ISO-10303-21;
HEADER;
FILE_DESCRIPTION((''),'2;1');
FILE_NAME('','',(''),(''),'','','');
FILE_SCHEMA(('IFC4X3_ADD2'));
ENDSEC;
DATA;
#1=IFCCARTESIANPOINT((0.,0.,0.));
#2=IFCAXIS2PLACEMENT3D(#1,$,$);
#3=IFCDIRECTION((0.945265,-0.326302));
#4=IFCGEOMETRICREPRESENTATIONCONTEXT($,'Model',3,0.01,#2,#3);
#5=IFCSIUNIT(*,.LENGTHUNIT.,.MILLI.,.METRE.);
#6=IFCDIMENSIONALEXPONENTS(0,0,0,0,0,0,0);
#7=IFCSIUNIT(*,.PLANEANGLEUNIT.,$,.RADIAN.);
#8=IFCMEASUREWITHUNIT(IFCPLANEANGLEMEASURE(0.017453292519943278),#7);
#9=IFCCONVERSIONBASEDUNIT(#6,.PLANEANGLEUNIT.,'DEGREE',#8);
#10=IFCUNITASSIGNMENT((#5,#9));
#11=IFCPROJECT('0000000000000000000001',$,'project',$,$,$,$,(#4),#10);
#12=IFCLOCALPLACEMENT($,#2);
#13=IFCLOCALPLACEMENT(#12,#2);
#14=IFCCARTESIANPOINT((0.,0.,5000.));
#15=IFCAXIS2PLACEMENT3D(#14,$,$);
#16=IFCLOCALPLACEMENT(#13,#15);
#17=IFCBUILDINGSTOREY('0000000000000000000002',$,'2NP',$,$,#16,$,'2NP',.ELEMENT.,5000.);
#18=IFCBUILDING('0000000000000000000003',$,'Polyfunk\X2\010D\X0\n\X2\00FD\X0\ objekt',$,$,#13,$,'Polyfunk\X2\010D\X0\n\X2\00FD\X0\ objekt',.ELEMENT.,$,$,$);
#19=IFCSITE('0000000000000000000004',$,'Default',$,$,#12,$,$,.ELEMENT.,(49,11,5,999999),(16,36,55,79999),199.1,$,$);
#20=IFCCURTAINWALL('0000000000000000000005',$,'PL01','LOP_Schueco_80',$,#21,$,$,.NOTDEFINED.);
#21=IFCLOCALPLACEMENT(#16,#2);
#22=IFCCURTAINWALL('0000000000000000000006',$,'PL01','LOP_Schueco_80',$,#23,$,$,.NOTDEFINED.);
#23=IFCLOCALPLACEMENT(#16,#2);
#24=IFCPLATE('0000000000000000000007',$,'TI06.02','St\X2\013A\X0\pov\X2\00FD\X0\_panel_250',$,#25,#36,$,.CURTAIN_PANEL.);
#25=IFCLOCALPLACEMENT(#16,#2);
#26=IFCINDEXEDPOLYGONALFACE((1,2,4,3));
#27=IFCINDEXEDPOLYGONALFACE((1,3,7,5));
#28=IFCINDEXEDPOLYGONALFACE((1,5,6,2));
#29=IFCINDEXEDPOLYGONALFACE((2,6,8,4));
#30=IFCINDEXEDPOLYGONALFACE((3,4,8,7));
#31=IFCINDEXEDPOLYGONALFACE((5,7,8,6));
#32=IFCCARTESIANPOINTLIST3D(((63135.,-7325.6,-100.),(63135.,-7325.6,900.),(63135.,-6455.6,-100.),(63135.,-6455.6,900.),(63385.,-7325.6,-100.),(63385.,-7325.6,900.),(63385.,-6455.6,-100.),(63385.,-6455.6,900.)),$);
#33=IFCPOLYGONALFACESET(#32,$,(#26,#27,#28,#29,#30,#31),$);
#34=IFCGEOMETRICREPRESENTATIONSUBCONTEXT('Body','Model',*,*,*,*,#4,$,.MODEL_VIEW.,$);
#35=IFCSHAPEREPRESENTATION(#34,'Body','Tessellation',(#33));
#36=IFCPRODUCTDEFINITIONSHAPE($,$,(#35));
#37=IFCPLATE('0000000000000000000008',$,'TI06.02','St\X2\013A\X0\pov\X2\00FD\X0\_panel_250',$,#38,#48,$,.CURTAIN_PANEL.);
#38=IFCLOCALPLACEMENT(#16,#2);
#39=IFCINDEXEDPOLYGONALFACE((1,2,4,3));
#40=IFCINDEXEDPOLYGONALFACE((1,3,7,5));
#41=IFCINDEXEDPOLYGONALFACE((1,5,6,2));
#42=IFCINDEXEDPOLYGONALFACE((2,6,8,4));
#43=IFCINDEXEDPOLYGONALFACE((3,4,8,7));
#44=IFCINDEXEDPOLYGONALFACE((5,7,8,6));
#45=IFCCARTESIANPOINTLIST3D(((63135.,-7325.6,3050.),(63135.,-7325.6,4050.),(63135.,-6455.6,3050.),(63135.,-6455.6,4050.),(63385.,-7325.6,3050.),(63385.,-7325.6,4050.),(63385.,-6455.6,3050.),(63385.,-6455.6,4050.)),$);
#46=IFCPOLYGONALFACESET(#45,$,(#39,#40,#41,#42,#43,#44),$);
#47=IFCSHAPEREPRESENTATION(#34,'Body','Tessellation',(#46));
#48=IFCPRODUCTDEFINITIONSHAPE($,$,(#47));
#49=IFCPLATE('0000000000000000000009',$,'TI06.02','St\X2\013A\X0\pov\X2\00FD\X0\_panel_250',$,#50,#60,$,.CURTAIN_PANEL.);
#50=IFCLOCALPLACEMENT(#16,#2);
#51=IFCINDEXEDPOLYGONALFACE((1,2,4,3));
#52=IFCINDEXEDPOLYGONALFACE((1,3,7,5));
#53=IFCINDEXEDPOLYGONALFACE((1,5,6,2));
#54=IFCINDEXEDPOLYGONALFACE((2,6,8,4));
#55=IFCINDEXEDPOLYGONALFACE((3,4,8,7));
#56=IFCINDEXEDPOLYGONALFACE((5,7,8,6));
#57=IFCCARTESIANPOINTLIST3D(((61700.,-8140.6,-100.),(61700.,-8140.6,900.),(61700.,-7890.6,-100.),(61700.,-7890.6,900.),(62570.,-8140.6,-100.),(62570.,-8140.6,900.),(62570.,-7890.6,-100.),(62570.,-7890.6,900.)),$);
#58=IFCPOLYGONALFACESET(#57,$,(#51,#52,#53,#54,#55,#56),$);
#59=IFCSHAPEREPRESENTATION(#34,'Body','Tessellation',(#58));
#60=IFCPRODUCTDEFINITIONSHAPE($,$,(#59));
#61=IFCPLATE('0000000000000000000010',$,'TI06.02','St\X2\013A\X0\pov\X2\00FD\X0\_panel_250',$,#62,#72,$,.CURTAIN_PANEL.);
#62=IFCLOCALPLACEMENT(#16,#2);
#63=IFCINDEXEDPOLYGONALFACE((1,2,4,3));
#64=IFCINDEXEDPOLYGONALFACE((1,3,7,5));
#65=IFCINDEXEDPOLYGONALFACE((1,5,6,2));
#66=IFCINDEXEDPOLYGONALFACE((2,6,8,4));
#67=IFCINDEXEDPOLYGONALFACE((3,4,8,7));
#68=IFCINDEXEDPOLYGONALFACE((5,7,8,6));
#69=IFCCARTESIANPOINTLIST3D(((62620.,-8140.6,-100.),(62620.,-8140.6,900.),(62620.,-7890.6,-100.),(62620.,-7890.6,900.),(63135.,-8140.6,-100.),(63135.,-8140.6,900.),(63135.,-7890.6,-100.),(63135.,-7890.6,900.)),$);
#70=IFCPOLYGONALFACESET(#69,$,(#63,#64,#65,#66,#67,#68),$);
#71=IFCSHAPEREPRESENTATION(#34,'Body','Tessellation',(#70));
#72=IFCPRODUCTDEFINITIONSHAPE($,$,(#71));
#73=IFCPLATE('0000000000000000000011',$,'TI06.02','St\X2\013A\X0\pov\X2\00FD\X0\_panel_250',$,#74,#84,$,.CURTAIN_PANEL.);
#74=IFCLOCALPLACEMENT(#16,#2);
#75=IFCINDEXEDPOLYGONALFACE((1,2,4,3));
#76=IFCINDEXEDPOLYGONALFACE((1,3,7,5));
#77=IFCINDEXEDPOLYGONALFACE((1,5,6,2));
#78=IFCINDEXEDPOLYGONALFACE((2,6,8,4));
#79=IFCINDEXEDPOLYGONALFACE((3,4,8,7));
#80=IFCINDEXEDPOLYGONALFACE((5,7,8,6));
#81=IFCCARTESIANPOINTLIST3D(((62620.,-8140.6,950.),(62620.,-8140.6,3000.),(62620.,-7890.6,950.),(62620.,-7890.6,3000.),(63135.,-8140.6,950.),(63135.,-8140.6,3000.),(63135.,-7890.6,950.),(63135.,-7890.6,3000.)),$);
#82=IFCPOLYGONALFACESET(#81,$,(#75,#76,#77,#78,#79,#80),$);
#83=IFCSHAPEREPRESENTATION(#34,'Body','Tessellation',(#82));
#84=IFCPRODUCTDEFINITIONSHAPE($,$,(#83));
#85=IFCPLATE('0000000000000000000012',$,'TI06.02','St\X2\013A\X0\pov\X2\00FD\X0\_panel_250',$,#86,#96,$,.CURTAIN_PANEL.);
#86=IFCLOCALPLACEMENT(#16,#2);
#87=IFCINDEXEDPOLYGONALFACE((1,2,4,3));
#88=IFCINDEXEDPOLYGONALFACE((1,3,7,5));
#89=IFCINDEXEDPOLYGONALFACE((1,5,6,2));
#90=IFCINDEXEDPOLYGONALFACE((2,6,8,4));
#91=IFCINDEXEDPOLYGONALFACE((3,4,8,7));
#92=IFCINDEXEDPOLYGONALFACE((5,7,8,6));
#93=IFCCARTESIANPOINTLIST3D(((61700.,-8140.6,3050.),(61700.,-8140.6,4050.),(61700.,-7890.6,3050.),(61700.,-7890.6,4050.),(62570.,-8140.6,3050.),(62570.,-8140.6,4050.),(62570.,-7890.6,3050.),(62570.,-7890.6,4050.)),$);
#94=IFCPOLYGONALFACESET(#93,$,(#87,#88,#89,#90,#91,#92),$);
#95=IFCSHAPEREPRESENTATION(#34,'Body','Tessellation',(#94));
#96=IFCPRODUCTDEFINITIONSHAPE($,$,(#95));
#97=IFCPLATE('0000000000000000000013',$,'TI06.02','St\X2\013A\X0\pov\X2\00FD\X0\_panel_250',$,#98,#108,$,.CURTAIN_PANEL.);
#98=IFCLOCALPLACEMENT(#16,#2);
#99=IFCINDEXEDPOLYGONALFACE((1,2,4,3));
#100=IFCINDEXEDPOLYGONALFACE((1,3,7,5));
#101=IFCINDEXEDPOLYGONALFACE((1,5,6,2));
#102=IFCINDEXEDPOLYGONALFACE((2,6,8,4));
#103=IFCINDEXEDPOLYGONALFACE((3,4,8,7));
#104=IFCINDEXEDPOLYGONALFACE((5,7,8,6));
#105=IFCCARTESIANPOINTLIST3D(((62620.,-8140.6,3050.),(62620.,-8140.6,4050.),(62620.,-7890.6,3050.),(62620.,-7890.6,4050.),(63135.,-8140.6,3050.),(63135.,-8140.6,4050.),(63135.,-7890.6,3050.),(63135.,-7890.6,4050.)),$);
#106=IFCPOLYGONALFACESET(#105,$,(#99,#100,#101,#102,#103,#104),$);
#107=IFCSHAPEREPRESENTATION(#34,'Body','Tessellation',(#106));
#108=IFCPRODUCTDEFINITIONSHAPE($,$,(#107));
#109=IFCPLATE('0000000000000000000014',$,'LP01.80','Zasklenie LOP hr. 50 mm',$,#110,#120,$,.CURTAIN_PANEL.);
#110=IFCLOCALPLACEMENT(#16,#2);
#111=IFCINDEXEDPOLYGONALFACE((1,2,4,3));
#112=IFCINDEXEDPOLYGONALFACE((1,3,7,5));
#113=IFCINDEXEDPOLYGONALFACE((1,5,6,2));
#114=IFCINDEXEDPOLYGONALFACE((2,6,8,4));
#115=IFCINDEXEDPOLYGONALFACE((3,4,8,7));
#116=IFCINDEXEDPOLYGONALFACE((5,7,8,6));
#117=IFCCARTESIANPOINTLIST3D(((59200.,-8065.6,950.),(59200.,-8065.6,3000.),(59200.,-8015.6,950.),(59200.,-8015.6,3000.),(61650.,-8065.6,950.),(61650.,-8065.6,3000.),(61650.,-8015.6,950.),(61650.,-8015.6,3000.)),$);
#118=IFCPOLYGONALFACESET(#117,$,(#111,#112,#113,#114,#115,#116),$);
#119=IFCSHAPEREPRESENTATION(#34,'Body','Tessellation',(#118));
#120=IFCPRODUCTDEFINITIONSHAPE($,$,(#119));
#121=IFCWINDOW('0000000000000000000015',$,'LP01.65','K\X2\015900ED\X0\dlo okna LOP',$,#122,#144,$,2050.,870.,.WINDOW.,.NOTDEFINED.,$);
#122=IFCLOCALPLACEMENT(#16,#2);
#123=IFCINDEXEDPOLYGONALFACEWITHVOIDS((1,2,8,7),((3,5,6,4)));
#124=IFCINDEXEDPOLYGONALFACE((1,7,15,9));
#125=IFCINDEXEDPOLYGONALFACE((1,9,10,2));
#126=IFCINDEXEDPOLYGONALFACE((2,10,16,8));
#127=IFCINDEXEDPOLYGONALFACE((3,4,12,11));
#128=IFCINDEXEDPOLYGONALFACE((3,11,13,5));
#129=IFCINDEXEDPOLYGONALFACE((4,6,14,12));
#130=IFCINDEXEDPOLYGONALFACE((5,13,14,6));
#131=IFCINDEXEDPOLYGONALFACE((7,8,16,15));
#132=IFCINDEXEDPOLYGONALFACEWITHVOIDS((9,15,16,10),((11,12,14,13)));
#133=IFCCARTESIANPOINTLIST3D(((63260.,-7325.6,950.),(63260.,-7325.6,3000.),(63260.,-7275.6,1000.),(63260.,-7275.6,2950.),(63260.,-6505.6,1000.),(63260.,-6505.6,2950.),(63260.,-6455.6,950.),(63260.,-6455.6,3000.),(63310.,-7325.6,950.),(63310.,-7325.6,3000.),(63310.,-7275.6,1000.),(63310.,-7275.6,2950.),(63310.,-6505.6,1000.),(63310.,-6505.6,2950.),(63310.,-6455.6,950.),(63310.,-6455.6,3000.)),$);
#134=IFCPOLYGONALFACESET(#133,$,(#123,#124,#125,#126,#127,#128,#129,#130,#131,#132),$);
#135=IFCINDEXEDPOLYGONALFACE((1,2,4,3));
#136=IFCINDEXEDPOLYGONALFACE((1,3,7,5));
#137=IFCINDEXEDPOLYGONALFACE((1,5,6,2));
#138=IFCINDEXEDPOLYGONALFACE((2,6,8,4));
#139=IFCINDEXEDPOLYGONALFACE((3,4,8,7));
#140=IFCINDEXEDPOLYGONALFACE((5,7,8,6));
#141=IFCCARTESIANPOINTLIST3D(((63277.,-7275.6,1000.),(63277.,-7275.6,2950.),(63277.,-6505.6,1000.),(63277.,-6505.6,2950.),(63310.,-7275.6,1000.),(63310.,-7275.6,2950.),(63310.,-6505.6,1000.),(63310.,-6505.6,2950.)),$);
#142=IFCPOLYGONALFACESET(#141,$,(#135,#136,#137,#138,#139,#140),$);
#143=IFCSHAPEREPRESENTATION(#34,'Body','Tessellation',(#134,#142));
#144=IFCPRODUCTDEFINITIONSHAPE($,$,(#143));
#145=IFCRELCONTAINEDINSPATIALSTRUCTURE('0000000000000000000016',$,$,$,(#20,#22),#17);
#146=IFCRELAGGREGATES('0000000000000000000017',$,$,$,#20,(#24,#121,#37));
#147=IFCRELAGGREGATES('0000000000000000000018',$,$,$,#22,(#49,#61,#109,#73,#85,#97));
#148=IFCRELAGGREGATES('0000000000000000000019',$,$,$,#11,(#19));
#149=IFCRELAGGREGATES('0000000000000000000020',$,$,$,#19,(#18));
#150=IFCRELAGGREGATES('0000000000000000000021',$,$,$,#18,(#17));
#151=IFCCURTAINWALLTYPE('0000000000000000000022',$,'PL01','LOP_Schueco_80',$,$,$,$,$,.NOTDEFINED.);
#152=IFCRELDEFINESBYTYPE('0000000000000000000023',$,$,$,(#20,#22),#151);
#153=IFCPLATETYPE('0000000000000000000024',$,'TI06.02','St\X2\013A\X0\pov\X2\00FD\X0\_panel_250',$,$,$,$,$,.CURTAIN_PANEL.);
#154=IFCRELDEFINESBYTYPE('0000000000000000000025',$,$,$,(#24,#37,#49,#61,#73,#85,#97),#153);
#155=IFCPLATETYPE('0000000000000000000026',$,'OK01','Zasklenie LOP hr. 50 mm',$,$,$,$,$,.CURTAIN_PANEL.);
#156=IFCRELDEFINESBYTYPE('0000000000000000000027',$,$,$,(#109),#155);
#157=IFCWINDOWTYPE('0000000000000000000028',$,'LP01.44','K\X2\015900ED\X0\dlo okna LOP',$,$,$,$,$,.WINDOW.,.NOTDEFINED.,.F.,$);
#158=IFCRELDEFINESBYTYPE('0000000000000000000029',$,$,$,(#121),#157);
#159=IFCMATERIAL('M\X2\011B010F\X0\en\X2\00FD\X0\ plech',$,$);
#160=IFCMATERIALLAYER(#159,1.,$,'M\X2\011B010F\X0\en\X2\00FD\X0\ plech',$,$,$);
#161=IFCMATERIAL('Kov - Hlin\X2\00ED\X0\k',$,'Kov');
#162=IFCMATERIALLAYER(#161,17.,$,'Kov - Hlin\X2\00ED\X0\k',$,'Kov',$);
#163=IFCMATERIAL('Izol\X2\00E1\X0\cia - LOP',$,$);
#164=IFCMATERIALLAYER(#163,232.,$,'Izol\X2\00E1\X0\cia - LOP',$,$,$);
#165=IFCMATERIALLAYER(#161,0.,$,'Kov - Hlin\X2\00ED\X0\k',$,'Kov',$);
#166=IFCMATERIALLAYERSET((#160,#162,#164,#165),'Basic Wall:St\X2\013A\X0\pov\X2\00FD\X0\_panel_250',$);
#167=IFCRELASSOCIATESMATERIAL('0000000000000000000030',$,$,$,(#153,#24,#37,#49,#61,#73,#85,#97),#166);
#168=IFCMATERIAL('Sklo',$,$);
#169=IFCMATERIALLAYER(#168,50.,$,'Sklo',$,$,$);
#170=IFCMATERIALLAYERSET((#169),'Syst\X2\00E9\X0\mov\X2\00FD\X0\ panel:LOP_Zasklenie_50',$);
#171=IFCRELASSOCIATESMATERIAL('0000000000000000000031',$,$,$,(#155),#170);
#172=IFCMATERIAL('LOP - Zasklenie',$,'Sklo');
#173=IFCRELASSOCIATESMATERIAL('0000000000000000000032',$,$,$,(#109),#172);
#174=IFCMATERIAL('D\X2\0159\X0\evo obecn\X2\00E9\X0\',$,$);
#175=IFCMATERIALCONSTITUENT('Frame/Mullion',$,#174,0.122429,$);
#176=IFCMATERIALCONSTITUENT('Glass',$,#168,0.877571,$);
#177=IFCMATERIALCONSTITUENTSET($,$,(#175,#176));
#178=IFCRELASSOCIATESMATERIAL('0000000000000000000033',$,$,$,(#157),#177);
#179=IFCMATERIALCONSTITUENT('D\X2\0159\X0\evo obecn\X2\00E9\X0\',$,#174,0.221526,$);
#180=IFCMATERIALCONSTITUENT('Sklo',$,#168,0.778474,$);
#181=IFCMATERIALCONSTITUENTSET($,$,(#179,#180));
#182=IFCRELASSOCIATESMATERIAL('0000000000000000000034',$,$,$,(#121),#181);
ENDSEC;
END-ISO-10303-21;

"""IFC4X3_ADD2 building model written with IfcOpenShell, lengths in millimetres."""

from ifc_helpers import new_model, entity, si_unit, converted_unit, direction, frame, frame_2d, origin, origin_2d_with_axis, place, context, subcontext, project, spatial, polyline, rectangle, outline, extrude, source, transform, mapped, material, layer, layer_set, layer_usage, constituent, constituent_set, type_object, type_shapes, element, aggregate, save


model = new_model("IFC4X3_ADD2")

# Units and contexts
model_context = context("Model", 3, precision=0.01, world=origin(), true_north=direction((0.945265, -0.326302)))
body_context = subcontext(model_context, "Body", "Model", "MODEL_VIEW")
ifc_project = project(units=[si_unit("LENGTHUNIT", "METRE", prefix="MILLI"), converted_unit("PLANEANGLEUNIT", "DEGREE", entity("IfcPlaneAngleMeasure", 0.017453292519943278), si_unit("PLANEANGLEUNIT", "RADIAN"), dimensions=[0, 0, 0, 0, 0, 0, 0])], contexts=[model_context])

# Site, building, storey
site_placement = place(None, origin())
site = spatial("IfcSite", under=ifc_project, at=site_placement, Name="Default", CompositionType="ELEMENT", RefLatitude=(49, 11, 5, 999999), RefLongitude=(16, 36, 55, 79999), RefElevation=199.1)
building_placement = place(site_placement, origin())
building = spatial("IfcBuilding", under=site, at=building_placement, Name="Polyfunkčný objekt", LongName="Polyfunkčný objekt", CompositionType="ELEMENT")
storey_placement = place(building_placement, frame((0.0, 0.0, 5000.0)))
storey = spatial("IfcBuildingStorey", under=building, at=storey_placement, Name="2NP", LongName="2NP", CompositionType="ELEMENT", Elevation=5000.0)

# Curtain walls
curtain_wall_type = type_object("IfcCurtainWallType", Name="PL01", Description="LOP_Schueco_80", PredefinedType="NOTDEFINED")
curtain_wall_1_placement = place(storey_placement, frame((0.0, 0.0, -5000.0)))
curtain_wall_1 = element("IfcCurtainWall", 1, at=curtain_wall_1_placement, inside=storey, type_object=curtain_wall_type, Name="PL01", Description="LOP_Schueco_80", PredefinedType="NOTDEFINED")
curtain_wall_2_placement = place(storey_placement, frame((0.0, 0.0, -5000.0)))
curtain_wall_2 = element("IfcCurtainWall", 2, at=curtain_wall_2_placement, inside=storey, type_object=curtain_wall_type, Name="PL01", Description="LOP_Schueco_80", PredefinedType="NOTDEFINED")

# Plates
ifc_material_1 = material(Name="Měďený plech")
ifc_layer_1 = layer(ifc_material_1, 1.0, Name="Měďený plech")
ifc_material_2 = material(Name="Kov - Hliník", Category="Kov")
ifc_layer_2 = layer(ifc_material_2, 17.0, Name="Kov - Hliník", Category="Kov")
ifc_material_3 = material(Name="Izolácia - LOP")
ifc_layer_3 = layer(ifc_material_3, 232.0, Name="Izolácia - LOP")
ifc_layer_4 = layer(ifc_material_2, 0.0, Name="Kov - Hliník", Category="Kov")
ifc_layer_set_1 = layer_set([ifc_layer_1, ifc_layer_2, ifc_layer_3, ifc_layer_4], Name="Basic Wall:Stĺpový_panel_250")
ifc_layer_usage_1 = layer_usage(ifc_layer_set_1, "AXIS2", "NEGATIVE", 125.0)
plate_type_1 = type_object("IfcPlateType", Name="TI06.02", Description="Stĺpový_panel_250", PredefinedType="CURTAIN_PANEL", material=ifc_layer_set_1)
plate_1_placement = place(storey_placement, frame((63260.0, -6455.6, -100.0), z_axis=(0.0, 0.0, 1.0), x_axis=(0.0, -1.0, 0.0)))
plate_1 = element("IfcPlate", 3, at=plate_1_placement, type_object=plate_type_1, material=ifc_layer_usage_1, Name="TI06.02", Description="Stĺpový_panel_250", PredefinedType="CURTAIN_PANEL", context=body_context, shape_type="SweptSolid", body=[
    extrude(rectangle(XDim=250.0, YDim=870.0, at=frame_2d((0.0, 0.0), x_axis=(1.0, 0.0))), frame((435.0, 0.0, 0.0), z_axis=(0.0, 0.0, 1.0), x_axis=(0.0, 1.0, 0.0)), (0.0, 0.0, 1.0), 1000.0),
])
ifc_layer_usage_2 = layer_usage(ifc_layer_set_1, "AXIS2", "NEGATIVE", 125.0)
plate_2_placement = place(storey_placement, frame((63260.0, -6455.6, 3050.0), z_axis=(0.0, 0.0, 1.0), x_axis=(0.0, -1.0, 0.0)))
plate_2 = element("IfcPlate", 4, at=plate_2_placement, type_object=plate_type_1, material=ifc_layer_usage_2, Name="TI06.02", Description="Stĺpový_panel_250", PredefinedType="CURTAIN_PANEL", context=body_context, shape_type="SweptSolid", body=[
    extrude(rectangle(XDim=250.0, YDim=870.0, at=frame_2d((0.0, 0.0), x_axis=(1.0, 0.0))), frame((435.0, 0.0, 0.0), z_axis=(0.0, 0.0, 1.0), x_axis=(0.0, 1.0, 0.0)), (0.0, 0.0, 1.0), 1000.0),
])
ifc_layer_usage_3 = layer_usage(ifc_layer_set_1, "AXIS2", "POSITIVE", -125.0)
plate_3_placement = place(storey_placement, frame((61700.0, -8015.6, -100.0)))
plate_3 = element("IfcPlate", 5, at=plate_3_placement, type_object=plate_type_1, material=ifc_layer_usage_3, Name="TI06.02", Description="Stĺpový_panel_250", PredefinedType="CURTAIN_PANEL", context=body_context, shape_type="SweptSolid", body=[
    extrude(rectangle(XDim=250.0, YDim=870.0, at=frame_2d((0.0, 0.0), x_axis=(1.0, 0.0))), frame((435.0, 0.0, 0.0), z_axis=(0.0, 0.0, 1.0), x_axis=(0.0, 1.0, 0.0)), (0.0, 0.0, 1.0), 1000.0),
])
ifc_layer_usage_4 = layer_usage(ifc_layer_set_1, "AXIS2", "POSITIVE", -125.0)
plate_4_placement = place(storey_placement, frame((62620.0, -8015.6, -100.0)))
plate_4 = element("IfcPlate", 6, at=plate_4_placement, type_object=plate_type_1, material=ifc_layer_usage_4, Name="TI06.02", Description="Stĺpový_panel_250", PredefinedType="CURTAIN_PANEL", context=body_context, shape_type="SweptSolid", body=[
    extrude(rectangle(XDim=250.0, YDim=515.0, at=frame_2d((0.0, 0.0), x_axis=(1.0, 0.0))), frame((257.5, 0.0, 0.0), z_axis=(0.0, 0.0, 1.0), x_axis=(0.0, 1.0, 0.0)), (0.0, 0.0, 1.0), 1000.0),
])
ifc_layer_usage_5 = layer_usage(ifc_layer_set_1, "AXIS2", "POSITIVE", -125.0)
plate_5_placement = place(storey_placement, frame((62620.0, -8015.6, 950.0)))
plate_5 = element("IfcPlate", 7, at=plate_5_placement, type_object=plate_type_1, material=ifc_layer_usage_5, Name="TI06.02", Description="Stĺpový_panel_250", PredefinedType="CURTAIN_PANEL", context=body_context, shape_type="SweptSolid", body=[
    extrude(rectangle(XDim=250.0, YDim=515.0, at=frame_2d((0.0, 0.0), x_axis=(1.0, 0.0))), frame((257.5, 0.0, 0.0), z_axis=(0.0, 0.0, 1.0), x_axis=(0.0, 1.0, 0.0)), (0.0, 0.0, 1.0), 2050.0),
])
ifc_layer_usage_6 = layer_usage(ifc_layer_set_1, "AXIS2", "POSITIVE", -125.0)
plate_6_placement = place(storey_placement, frame((61700.0, -8015.6, 3050.0)))
plate_6 = element("IfcPlate", 8, at=plate_6_placement, type_object=plate_type_1, material=ifc_layer_usage_6, Name="TI06.02", Description="Stĺpový_panel_250", PredefinedType="CURTAIN_PANEL", context=body_context, shape_type="SweptSolid", body=[
    extrude(rectangle(XDim=250.0, YDim=870.0, at=frame_2d((0.0, 0.0), x_axis=(1.0, 0.0))), frame((435.0, 0.0, 0.0), z_axis=(0.0, 0.0, 1.0), x_axis=(0.0, 1.0, 0.0)), (0.0, 0.0, 1.0), 1000.0),
])
ifc_layer_usage_7 = layer_usage(ifc_layer_set_1, "AXIS2", "POSITIVE", -125.0)
plate_7_placement = place(storey_placement, frame((62620.0, -8015.6, 3050.0)))
plate_7 = element("IfcPlate", 9, at=plate_7_placement, type_object=plate_type_1, material=ifc_layer_usage_7, Name="TI06.02", Description="Stĺpový_panel_250", PredefinedType="CURTAIN_PANEL", context=body_context, shape_type="SweptSolid", body=[
    extrude(rectangle(XDim=250.0, YDim=515.0, at=frame_2d((0.0, 0.0), x_axis=(1.0, 0.0))), frame((257.5, 0.0, 0.0), z_axis=(0.0, 0.0, 1.0), x_axis=(0.0, 1.0, 0.0)), (0.0, 0.0, 1.0), 1000.0),
])
ifc_material_4 = material(Name="LOP - Zasklenie", Category="Sklo")
ifc_material_5 = material(Name="Sklo")
ifc_layer_5 = layer(ifc_material_5, 50.0, Name="Sklo")
ifc_layer_set_2 = layer_set([ifc_layer_5], Name="Systémový panel:LOP_Zasklenie_50")
plate_type_2 = type_object("IfcPlateType", Name="OK01", Description="Zasklenie LOP hr. 50 mm", PredefinedType="CURTAIN_PANEL", material=ifc_layer_set_2)
shared_shape_1 = source(origin(), body_context, "Body", "SweptSolid", [
    extrude(rectangle(XDim=50.0, YDim=2450.0, at=origin_2d_with_axis()), frame((0.0, -25.0, 0.0), z_axis=(0.0, 0.0, 1.0), x_axis=(0.0, 1.0, 0.0)), (0.0, 0.0, 1.0), 2050.0),
])
type_shapes(plate_type_2, [shared_shape_1])
plate_8_placement = place(curtain_wall_2_placement, frame((60425.0, -8015.6, 5950.0)))
plate_8 = element("IfcPlate", 10, at=plate_8_placement, type_object=plate_type_2, material=ifc_material_4, Name="LP01.80", Description="Zasklenie LOP hr. 50 mm", PredefinedType="CURTAIN_PANEL", context=body_context, shape_type="MappedRepresentation", body=[
    mapped(shared_shape_1, transform((0.0, 0.0, 0.0), scale=1.0)),
])

# Window
ifc_material_6 = material(Name="Dřevo obecné")
ifc_constituent_1 = constituent(ifc_material_6, Name="Dřevo obecné", fraction=0.221526)
ifc_constituent_2 = constituent(ifc_material_5, Name="Sklo", fraction=0.778474)
ifc_constituent_set_1 = constituent_set(constituents=[ifc_constituent_1, ifc_constituent_2])
ifc_constituent_3 = constituent(ifc_material_6, Name="Frame/Mullion", fraction=0.122429)
ifc_constituent_4 = constituent(ifc_material_5, Name="Glass", fraction=0.877571)
ifc_constituent_set_2 = constituent_set(constituents=[ifc_constituent_3, ifc_constituent_4])
window_type_1 = type_object("IfcWindowType", Name="LP01.44", Description="Křídlo okna LOP", ParameterTakesPrecedence=False, PartitioningType="NOTDEFINED", PredefinedType="WINDOW", material=ifc_constituent_set_2)
shared_shape_2 = source(origin(), body_context, "Body", "SweptSolid", [
    extrude(outline(polyline([(-1025.0, -435.0), (1025.0, -435.0), (1025.0, 435.0), (-1025.0, 435.0), (-1025.0, -435.0)]), holes=[polyline([(-975.0, -385.0), (-975.0, 385.0), (975.0, 385.0), (975.0, -385.0), (-975.0, -385.0)])]), frame((0.0, 0.0, 1025.0), z_axis=(0.0, 1.0, 0.0), x_axis=(0.0, 0.0, -1.0)), (0.0, 0.0, 1.0), 50.0),
    extrude(rectangle(XDim=33.0, YDim=770.0, at=origin_2d_with_axis()), frame((0.0, 33.5, 50.0), z_axis=(0.0, 0.0, 1.0), x_axis=(0.0, -1.0, 0.0)), (0.0, 0.0, 1.0), 1950.0),
])
type_shapes(window_type_1, [shared_shape_2])
window_1_placement = place(curtain_wall_1_placement, frame((63260.0, -6890.6, 5950.0), z_axis=(0.0, 0.0, 1.0), x_axis=(0.0, -1.0, 0.0)))
window_1 = element("IfcWindow", 11, at=window_1_placement, type_object=window_type_1, material=ifc_constituent_set_1, Name="LP01.65", Description="Křídlo okna LOP", OverallHeight=2050.0, OverallWidth=870.0, PartitioningType="NOTDEFINED", PredefinedType="WINDOW", context=body_context, shape_type="MappedRepresentation", body=[
    mapped(shared_shape_2, transform((0.0, 0.0, 0.0), scale=1.0)),
])
aggregate(curtain_wall_1, [plate_1, window_1, plate_2])
aggregate(curtain_wall_2, [plate_3, plate_4, plate_8, plate_5, plate_6, plate_7])

save(model, "model.ifc")
